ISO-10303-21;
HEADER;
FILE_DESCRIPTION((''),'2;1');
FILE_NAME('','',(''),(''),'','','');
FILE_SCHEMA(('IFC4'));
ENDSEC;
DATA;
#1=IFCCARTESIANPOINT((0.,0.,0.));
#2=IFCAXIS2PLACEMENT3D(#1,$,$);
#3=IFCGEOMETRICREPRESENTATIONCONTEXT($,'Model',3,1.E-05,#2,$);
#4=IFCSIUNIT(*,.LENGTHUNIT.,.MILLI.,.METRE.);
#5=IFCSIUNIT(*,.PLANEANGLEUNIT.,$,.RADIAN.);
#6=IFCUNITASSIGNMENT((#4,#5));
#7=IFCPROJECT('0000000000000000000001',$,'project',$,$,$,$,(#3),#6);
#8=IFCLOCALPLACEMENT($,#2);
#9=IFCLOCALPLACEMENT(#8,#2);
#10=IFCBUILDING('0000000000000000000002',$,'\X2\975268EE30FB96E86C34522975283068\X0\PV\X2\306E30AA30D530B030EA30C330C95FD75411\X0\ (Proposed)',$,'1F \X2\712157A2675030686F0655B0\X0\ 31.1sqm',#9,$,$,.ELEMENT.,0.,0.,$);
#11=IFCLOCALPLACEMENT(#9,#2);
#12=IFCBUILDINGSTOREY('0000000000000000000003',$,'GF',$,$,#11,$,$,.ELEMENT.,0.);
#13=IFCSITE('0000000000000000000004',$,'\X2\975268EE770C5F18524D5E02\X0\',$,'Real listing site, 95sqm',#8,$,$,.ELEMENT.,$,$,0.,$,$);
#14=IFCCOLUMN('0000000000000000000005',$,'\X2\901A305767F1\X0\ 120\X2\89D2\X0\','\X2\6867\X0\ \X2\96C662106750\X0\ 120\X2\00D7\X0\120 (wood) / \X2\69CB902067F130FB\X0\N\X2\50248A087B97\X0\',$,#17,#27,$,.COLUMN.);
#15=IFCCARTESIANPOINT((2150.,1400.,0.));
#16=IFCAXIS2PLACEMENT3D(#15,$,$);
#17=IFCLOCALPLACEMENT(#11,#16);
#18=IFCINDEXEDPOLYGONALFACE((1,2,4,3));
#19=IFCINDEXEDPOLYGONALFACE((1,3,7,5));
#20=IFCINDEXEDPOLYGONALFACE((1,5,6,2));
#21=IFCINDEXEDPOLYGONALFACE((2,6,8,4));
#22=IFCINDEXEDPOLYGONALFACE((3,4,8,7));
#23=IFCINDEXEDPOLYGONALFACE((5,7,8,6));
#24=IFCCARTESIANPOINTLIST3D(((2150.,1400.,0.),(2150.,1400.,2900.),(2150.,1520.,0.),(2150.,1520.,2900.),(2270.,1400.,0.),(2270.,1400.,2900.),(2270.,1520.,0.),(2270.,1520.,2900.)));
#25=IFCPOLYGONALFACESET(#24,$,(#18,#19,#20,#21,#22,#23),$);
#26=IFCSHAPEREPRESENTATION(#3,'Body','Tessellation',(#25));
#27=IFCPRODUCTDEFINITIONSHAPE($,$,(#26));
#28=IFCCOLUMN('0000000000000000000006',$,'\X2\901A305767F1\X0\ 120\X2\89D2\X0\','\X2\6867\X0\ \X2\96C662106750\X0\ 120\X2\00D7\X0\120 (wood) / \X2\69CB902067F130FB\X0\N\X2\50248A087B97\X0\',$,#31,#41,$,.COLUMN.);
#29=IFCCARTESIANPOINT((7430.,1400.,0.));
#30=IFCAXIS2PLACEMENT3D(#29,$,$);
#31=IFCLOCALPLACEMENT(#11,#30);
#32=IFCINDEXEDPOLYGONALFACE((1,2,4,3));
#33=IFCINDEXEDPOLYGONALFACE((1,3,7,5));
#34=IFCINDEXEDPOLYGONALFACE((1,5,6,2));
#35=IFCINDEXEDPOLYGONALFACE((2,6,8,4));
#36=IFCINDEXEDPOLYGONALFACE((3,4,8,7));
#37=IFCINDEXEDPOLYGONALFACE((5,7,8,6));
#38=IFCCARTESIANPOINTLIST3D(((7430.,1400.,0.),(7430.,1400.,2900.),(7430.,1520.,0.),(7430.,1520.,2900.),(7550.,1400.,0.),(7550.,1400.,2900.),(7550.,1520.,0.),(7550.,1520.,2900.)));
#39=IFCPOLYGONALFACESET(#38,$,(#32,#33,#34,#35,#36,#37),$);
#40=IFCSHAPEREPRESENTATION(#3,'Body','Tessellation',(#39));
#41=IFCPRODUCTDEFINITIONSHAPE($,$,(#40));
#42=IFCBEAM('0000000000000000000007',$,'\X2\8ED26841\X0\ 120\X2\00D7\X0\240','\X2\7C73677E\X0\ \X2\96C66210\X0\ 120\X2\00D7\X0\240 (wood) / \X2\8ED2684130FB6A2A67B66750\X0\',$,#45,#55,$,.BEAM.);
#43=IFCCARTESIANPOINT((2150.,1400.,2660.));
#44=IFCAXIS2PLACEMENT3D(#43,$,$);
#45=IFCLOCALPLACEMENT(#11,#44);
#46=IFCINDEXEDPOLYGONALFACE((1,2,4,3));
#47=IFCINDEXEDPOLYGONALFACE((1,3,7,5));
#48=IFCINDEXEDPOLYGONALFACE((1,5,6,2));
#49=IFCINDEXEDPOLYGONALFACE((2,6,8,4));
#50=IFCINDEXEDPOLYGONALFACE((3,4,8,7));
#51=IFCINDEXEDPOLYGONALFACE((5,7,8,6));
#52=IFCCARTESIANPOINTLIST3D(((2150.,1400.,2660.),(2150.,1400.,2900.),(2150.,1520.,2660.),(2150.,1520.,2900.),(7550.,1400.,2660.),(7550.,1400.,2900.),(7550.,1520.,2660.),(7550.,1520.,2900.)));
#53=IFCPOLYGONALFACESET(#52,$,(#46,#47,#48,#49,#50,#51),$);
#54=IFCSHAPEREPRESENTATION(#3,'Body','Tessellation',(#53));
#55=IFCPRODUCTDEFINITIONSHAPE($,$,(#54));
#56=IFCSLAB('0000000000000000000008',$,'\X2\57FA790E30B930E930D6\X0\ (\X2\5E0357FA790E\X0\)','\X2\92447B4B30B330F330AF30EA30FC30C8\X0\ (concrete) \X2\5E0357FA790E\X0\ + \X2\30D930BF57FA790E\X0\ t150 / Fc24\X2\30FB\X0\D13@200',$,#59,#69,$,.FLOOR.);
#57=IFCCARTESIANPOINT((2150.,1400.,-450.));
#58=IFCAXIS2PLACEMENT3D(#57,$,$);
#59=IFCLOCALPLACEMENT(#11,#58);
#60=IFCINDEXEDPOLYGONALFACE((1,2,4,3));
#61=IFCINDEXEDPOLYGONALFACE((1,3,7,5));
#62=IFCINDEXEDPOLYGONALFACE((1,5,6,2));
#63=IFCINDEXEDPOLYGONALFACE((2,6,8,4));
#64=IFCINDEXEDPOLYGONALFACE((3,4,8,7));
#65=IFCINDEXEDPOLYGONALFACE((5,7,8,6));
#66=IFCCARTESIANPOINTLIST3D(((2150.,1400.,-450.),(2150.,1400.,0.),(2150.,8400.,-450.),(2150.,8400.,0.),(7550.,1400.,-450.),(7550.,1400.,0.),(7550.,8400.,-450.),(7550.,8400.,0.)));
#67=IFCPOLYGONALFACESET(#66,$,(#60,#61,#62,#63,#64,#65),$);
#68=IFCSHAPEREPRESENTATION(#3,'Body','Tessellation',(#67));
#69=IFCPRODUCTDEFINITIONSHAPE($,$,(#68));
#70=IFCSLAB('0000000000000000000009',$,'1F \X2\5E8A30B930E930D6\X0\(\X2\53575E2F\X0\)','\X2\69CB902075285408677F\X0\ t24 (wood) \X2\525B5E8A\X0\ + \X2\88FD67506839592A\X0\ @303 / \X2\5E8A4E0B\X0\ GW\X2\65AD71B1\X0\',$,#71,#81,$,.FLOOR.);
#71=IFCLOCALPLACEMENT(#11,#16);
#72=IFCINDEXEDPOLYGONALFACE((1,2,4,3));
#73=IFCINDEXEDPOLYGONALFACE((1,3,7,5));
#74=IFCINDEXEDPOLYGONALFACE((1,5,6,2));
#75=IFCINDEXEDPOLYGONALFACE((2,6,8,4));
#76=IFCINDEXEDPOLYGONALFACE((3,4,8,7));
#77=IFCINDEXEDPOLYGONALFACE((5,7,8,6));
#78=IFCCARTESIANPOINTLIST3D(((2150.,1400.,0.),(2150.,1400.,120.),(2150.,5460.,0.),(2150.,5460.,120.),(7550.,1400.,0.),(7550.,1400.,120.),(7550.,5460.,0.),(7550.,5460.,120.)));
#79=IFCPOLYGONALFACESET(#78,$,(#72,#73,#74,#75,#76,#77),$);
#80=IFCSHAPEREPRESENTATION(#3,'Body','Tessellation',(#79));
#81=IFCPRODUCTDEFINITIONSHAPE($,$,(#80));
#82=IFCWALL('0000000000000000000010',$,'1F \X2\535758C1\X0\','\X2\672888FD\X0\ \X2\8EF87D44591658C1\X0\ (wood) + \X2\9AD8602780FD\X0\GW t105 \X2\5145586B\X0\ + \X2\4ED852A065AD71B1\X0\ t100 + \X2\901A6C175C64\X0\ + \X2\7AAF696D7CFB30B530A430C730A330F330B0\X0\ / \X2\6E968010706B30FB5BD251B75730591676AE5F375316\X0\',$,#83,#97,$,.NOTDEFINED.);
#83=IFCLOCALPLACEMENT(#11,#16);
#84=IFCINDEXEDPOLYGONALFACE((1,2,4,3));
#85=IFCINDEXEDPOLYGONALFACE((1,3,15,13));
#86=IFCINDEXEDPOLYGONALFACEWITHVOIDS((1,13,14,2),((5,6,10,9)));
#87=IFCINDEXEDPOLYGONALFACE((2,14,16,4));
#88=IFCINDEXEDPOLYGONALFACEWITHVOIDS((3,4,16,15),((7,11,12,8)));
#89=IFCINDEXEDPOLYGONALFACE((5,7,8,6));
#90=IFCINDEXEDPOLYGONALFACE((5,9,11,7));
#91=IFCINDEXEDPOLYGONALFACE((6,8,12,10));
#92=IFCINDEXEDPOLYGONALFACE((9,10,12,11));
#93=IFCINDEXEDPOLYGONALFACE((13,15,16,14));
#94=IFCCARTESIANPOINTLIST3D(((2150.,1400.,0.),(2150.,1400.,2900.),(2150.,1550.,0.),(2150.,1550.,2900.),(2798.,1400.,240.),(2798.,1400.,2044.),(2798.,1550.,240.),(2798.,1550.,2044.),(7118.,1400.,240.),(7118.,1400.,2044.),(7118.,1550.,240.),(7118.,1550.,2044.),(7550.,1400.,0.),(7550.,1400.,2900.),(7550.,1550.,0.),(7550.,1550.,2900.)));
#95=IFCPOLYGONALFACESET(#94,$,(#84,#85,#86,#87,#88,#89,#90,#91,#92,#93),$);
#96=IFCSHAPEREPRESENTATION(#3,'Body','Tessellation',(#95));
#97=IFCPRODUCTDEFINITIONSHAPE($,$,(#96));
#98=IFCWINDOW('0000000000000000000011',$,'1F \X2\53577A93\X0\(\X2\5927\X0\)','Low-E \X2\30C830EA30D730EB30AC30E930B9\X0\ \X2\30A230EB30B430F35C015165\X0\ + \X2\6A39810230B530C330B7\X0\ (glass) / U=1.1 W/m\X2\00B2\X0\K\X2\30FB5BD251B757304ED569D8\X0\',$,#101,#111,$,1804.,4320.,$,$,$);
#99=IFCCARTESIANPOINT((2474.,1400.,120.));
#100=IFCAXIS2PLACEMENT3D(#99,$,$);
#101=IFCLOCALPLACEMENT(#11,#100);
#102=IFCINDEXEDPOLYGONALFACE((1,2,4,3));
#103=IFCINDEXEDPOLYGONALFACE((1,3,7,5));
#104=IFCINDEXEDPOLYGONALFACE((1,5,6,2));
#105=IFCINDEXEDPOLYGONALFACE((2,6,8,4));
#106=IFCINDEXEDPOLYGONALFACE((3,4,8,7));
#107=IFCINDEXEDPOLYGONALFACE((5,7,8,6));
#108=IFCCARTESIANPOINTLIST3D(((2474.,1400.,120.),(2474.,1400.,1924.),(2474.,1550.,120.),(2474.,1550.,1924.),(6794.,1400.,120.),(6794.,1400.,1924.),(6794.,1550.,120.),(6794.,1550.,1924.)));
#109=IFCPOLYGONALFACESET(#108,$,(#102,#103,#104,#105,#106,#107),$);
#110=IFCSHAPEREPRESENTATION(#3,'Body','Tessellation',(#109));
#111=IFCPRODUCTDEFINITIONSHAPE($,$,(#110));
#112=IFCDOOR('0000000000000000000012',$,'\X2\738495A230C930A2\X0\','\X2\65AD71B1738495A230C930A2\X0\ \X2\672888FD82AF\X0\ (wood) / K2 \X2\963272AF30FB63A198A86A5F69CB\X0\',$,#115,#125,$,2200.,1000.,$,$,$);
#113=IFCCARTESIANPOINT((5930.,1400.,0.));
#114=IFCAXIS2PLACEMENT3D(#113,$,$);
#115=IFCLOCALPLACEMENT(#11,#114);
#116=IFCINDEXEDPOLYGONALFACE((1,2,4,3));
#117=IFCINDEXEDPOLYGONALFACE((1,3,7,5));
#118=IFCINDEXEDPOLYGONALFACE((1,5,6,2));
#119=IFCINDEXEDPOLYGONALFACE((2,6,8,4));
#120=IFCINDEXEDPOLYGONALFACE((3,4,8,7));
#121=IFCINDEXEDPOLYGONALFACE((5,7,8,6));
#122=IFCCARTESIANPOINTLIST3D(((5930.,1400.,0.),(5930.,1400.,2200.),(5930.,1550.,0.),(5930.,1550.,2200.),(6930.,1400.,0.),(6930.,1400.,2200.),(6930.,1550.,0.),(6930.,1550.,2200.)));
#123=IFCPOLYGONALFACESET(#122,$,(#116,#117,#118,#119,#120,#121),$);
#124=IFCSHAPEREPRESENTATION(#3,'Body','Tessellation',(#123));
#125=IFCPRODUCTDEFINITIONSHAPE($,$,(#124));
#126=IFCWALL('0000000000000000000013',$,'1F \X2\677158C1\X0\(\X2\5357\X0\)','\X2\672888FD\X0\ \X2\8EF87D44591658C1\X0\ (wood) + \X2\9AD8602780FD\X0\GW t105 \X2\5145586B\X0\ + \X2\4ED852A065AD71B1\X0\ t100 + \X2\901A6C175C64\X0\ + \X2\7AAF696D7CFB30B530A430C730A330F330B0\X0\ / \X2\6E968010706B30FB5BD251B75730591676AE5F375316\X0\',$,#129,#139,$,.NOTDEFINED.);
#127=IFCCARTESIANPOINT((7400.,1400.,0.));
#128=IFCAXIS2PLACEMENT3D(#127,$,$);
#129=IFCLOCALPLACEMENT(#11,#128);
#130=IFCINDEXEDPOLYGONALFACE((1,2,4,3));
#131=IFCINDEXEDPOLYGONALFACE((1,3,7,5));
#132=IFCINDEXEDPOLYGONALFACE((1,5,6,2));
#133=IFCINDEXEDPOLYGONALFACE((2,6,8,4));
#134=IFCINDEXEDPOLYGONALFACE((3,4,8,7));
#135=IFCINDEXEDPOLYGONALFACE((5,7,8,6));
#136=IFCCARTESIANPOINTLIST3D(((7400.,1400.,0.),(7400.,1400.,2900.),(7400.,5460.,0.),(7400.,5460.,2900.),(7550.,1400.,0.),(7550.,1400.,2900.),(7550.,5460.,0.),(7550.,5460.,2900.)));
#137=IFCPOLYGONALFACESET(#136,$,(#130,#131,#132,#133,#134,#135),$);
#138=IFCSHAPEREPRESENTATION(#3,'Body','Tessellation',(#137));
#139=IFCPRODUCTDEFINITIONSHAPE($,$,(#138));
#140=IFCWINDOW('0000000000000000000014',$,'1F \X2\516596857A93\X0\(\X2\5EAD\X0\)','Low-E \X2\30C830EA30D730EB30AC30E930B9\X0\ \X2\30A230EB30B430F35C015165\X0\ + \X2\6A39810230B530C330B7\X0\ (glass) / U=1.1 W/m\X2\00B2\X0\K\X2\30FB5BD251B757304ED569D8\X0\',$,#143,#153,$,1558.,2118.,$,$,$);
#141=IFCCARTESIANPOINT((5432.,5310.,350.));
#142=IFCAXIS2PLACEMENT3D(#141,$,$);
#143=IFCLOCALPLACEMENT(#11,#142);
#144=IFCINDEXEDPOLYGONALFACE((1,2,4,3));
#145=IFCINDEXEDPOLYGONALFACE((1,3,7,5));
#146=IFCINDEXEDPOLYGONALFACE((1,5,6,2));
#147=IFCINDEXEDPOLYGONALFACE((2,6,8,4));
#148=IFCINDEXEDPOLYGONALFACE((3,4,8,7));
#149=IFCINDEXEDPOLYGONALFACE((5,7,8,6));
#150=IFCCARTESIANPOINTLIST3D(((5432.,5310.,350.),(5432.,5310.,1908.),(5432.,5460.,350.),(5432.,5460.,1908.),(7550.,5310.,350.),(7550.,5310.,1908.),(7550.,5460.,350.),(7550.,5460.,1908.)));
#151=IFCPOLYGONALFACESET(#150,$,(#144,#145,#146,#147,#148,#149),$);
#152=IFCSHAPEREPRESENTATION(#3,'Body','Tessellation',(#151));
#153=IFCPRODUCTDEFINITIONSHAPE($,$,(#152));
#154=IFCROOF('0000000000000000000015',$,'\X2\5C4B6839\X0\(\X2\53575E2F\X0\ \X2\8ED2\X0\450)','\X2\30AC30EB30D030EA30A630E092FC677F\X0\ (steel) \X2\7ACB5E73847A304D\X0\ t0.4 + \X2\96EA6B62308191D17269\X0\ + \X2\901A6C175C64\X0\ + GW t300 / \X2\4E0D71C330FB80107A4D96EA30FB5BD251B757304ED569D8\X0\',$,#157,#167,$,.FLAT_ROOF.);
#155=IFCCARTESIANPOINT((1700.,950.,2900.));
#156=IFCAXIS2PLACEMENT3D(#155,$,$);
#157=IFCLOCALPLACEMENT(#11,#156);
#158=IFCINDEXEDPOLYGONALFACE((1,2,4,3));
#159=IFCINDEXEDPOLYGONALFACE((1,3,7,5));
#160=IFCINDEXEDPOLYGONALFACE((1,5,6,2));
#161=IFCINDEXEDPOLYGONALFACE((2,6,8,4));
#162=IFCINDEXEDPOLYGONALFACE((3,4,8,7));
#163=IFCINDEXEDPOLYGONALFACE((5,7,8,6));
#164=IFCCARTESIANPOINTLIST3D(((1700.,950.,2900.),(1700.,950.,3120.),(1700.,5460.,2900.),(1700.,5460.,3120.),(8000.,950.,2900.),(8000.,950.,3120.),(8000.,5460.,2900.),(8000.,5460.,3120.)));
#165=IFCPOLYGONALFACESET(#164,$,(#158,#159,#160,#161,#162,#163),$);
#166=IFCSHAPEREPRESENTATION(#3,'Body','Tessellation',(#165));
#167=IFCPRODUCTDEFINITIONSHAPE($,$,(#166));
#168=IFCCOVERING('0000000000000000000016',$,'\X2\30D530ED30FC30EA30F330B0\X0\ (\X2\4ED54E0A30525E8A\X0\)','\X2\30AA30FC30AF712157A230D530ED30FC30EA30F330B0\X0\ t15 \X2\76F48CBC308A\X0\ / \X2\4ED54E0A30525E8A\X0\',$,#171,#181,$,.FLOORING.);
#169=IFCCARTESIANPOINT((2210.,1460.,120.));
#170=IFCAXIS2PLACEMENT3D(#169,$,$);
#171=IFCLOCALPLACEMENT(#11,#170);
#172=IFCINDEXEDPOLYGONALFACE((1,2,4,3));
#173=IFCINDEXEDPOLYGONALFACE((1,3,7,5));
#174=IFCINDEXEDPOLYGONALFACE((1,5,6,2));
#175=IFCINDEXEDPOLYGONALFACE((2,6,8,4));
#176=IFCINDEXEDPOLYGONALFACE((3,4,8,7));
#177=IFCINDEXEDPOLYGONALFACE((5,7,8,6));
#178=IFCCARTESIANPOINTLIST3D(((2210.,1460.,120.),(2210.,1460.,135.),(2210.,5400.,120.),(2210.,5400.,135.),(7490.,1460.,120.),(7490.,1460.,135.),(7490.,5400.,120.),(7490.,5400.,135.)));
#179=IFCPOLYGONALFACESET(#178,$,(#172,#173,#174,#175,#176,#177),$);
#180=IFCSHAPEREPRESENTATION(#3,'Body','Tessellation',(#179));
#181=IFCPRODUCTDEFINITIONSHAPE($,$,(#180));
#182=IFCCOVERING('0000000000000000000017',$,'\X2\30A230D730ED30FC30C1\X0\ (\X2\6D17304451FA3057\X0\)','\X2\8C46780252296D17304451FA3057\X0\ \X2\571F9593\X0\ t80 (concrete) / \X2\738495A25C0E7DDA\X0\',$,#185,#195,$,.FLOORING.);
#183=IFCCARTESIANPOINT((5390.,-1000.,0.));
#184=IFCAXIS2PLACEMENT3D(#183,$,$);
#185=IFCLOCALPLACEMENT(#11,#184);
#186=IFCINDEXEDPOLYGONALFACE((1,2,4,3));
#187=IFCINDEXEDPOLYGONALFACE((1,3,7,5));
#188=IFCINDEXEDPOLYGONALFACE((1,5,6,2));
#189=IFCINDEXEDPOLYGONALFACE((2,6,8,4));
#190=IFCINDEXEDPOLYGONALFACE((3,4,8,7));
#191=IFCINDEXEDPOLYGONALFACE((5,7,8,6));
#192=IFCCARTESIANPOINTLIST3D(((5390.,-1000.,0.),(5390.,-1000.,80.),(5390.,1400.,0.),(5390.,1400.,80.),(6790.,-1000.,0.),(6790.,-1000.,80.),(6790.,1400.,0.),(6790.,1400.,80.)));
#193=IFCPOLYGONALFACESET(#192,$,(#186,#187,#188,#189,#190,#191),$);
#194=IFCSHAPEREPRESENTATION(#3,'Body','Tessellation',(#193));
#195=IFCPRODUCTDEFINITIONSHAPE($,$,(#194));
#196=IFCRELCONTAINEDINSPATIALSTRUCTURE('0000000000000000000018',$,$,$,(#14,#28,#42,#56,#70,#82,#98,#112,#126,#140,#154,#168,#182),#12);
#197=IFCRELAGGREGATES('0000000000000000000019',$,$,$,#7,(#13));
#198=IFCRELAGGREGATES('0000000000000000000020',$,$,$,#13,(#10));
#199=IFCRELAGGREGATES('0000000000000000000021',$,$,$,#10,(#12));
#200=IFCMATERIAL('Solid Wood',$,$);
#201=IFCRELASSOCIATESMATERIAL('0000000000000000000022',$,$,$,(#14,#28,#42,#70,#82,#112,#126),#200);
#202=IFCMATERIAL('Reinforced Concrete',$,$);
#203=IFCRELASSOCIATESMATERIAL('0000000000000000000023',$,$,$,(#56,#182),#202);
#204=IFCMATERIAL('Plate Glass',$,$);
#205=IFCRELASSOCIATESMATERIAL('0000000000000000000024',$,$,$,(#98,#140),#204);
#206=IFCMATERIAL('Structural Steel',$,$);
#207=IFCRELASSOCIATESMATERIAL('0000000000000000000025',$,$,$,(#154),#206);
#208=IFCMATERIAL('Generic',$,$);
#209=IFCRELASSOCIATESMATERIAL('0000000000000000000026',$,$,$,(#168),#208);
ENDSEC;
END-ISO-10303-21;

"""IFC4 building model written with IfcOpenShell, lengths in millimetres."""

from ifc_helpers import new_model, si_unit, frame, frame_2d, origin, place, context, project, spatial, rectangle, extrude, material, element, fill, save


model = new_model("IFC4")

# Units and contexts
model_context = context("Model", 3, precision=1e-05, world=origin())
ifc_project = project(units=[si_unit("LENGTHUNIT", "METRE", prefix="MILLI"), si_unit("PLANEANGLEUNIT", "RADIAN")], contexts=[model_context])

# Site, building, storey
site_placement = place(None, origin())
site = spatial("IfcSite", under=ifc_project, at=site_placement, Name="青森県弘前市", ObjectType="Real listing site, 95sqm", CompositionType="ELEMENT", RefElevation=0.0)
building_placement = place(site_placement, origin())
building = spatial("IfcBuilding", under=site, at=building_placement, Name="青森・雨水利用とPVのオフグリッド志向 (Proposed)", ObjectType="1F 無垢材と漆喰 31.1sqm", CompositionType="ELEMENT", ElevationOfRefHeight=0.0, ElevationOfTerrain=0.0)
storey_placement = place(building_placement, origin())
storey = spatial("IfcBuildingStorey", under=building, at=storey_placement, Name="GF", CompositionType="ELEMENT", Elevation=0.0)

# Columns
ifc_material_1 = material(Name="Solid Wood")
column_1_placement = place(storey_placement, frame((2150.0, 1400.0, 0.0)))
element("IfcColumn", 1, at=column_1_placement, inside=storey, material=ifc_material_1, Name="通し柱 120角", Description="桧 集成材 120×120 (wood) / 構造柱・N値計算", PredefinedType="COLUMN", context=model_context, shape_type="SweptSolid", body=[
    extrude(rectangle(XDim=120.0, YDim=120.0, at=frame_2d((60.0, 60.0))), frame((2150.0, 1400.0, 0.0)), (0.0, 0.0, 1.0), 2900.0),
])
column_2_placement = place(storey_placement, frame((7430.0, 1400.0, 0.0)))
element("IfcColumn", 2, at=column_2_placement, inside=storey, material=ifc_material_1, Name="通し柱 120角", Description="桧 集成材 120×120 (wood) / 構造柱・N値計算", PredefinedType="COLUMN", context=model_context, shape_type="SweptSolid", body=[
    extrude(rectangle(XDim=120.0, YDim=120.0, at=frame_2d((60.0, 60.0))), frame((7430.0, 1400.0, 0.0)), (0.0, 0.0, 1.0), 2900.0),
])

# Beam
beam_1_placement = place(storey_placement, frame((2150.0, 1400.0, 2660.0)))
element("IfcBeam", 3, at=beam_1_placement, inside=storey, material=ifc_material_1, Name="軒桁 120×240", Description="米松 集成 120×240 (wood) / 軒桁・横架材", PredefinedType="BEAM", context=model_context, shape_type="SweptSolid", body=[
    extrude(rectangle(XDim=5400.0, YDim=120.0, at=frame_2d((2700.0, 60.0))), frame((2150.0, 1400.0, 2660.0)), (0.0, 0.0, 1.0), 240.0),
])

# Slabs
ifc_material_2 = material(Name="Reinforced Concrete")
slab_1_placement = place(storey_placement, frame((2150.0, 1400.0, -450.0)))
element("IfcSlab", 4, at=slab_1_placement, inside=storey, material=ifc_material_2, Name="基礎スラブ (布基礎)", Description="鉄筋コンクリート (concrete) 布基礎 + ベタ基礎 t150 / Fc24・D13@200", PredefinedType="FLOOR", context=model_context, shape_type="SweptSolid", body=[
    extrude(rectangle(XDim=5400.0, YDim=7000.0, at=frame_2d((2700.0, 3500.0))), frame((2150.0, 1400.0, -450.0)), (0.0, 0.0, 1.0), 450.0),
])
slab_2_placement = place(storey_placement, frame((2150.0, 1400.0, 0.0)))
element("IfcSlab", 5, at=slab_2_placement, inside=storey, material=ifc_material_1, Name="1F 床スラブ(南帯)", Description="構造用合板 t24 (wood) 剛床 + 製材根太 @303 / 床下 GW断熱", PredefinedType="FLOOR", context=model_context, shape_type="SweptSolid", body=[
    extrude(rectangle(XDim=5400.0, YDim=4060.0, at=frame_2d((2700.0, 2030.0))), frame((2150.0, 1400.0, 0.0)), (0.0, 0.0, 1.0), 120.0),
])

# Wall, openings, window, door
wall_1_placement = place(storey_placement, frame((2150.0, 1400.0, 0.0)))
wall_1 = element("IfcWall", 6, at=wall_1_placement, inside=storey, material=ifc_material_1, Name="1F 南壁", Description="木製 軸組外壁 (wood) + 高性能GW t105 充填 + 付加断熱 t100 + 通気層 + 窯業系サイディング / 準耐火・寒冷地外皮強化", PredefinedType="NOTDEFINED", context=model_context, shape_type="SweptSolid", body=[
    extrude(rectangle(XDim=5400.0, YDim=150.0, at=frame_2d((2700.0, 75.0))), frame((2150.0, 1400.0, 0.0)), (0.0, 0.0, 1.0), 2900.0),
])
opening_1_placement = place(storey_placement, frame((2474.0, 1400.0, 120.0)))
opening_1 = element("IfcOpeningElement", 7, at=opening_1_placement, cuts=wall_1, PredefinedType="NOTDEFINED", context=model_context, shape_type="SweptSolid", body=[
    extrude(rectangle(XDim=4320.0, YDim=150.0, at=frame_2d((2160.0, 75.0))), frame((2474.0, 1400.0, 120.0)), (0.0, 0.0, 1.0), 1804.0),
])
opening_2_placement = place(storey_placement, frame((5930.0, 1400.0, 0.0)))
opening_2 = element("IfcOpeningElement", 8, at=opening_2_placement, cuts=wall_1, PredefinedType="NOTDEFINED", context=model_context, shape_type="SweptSolid", body=[
    extrude(rectangle(XDim=1000.0, YDim=150.0, at=frame_2d((500.0, 75.0))), frame((5930.0, 1400.0, 0.0)), (0.0, 0.0, 1.0), 2200.0),
])
ifc_material_3 = material(Name="Plate Glass")
window_1_placement = place(storey_placement, frame((2474.0, 1400.0, 120.0)))
window_1 = element("IfcWindow", 9, at=window_1_placement, inside=storey, material=ifc_material_3, Name="1F 南窓(大)", Description="Low-E トリプルガラス アルゴン封入 + 樹脂サッシ (glass) / U=1.1 W/m²K・寒冷地仕様", OverallHeight=1804.0, OverallWidth=4320.0, context=model_context, shape_type="SweptSolid", body=[
    extrude(rectangle(XDim=4320.0, YDim=150.0, at=frame_2d((2160.0, 75.0))), frame((2474.0, 1400.0, 120.0)), (0.0, 0.0, 1.0), 1804.0),
])
fill(opening_1, window_1)
door_1_placement = place(storey_placement, frame((5930.0, 1400.0, 0.0)))
door_1 = element("IfcDoor", 10, at=door_1_placement, inside=storey, material=ifc_material_1, Name="玄関ドア", Description="断熱玄関ドア 木製芯 (wood) / K2 防犯・採風機構", OverallHeight=2200.0, OverallWidth=1000.0, context=model_context, shape_type="SweptSolid", body=[
    extrude(rectangle(XDim=1000.0, YDim=150.0, at=frame_2d((500.0, 75.0))), frame((5930.0, 1400.0, 0.0)), (0.0, 0.0, 1.0), 2200.0),
])
fill(opening_2, door_1)

# Wall, opening, window
wall_2_placement = place(storey_placement, frame((7400.0, 1400.0, 0.0)))
wall_2 = element("IfcWall", 11, at=wall_2_placement, inside=storey, material=ifc_material_1, Name="1F 東壁(南)", Description="木製 軸組外壁 (wood) + 高性能GW t105 充填 + 付加断熱 t100 + 通気層 + 窯業系サイディング / 準耐火・寒冷地外皮強化", PredefinedType="NOTDEFINED", context=model_context, shape_type="SweptSolid", body=[
    extrude(rectangle(XDim=150.0, YDim=4060.0, at=frame_2d((75.0, 2030.0))), frame((7400.0, 1400.0, 0.0)), (0.0, 0.0, 1.0), 2900.0),
])
opening_3_placement = place(storey_placement, frame((5432.0, 5310.0, 350.0)))
opening_3 = element("IfcOpeningElement", 12, at=opening_3_placement, cuts=wall_2, PredefinedType="NOTDEFINED", context=model_context, shape_type="SweptSolid", body=[
    extrude(rectangle(XDim=2118.0, YDim=150.0, at=frame_2d((1059.0, 75.0))), frame((5432.0, 5310.0, 350.0)), (0.0, 0.0, 1.0), 1558.0),
])
window_2_placement = place(storey_placement, frame((5432.0, 5310.0, 350.0)))
window_2 = element("IfcWindow", 13, at=window_2_placement, inside=storey, material=ifc_material_3, Name="1F 入隅窓(庭)", Description="Low-E トリプルガラス アルゴン封入 + 樹脂サッシ (glass) / U=1.1 W/m²K・寒冷地仕様", OverallHeight=1558.0, OverallWidth=2118.0, context=model_context, shape_type="SweptSolid", body=[
    extrude(rectangle(XDim=2118.0, YDim=150.0, at=frame_2d((1059.0, 75.0))), frame((5432.0, 5310.0, 350.0)), (0.0, 0.0, 1.0), 1558.0),
])
fill(opening_3, window_2)

# Roof
ifc_material_4 = material(Name="Structural Steel")
roof_placement = place(storey_placement, frame((1700.0, 950.0, 2900.0)))
element("IfcRoof", 14, at=roof_placement, inside=storey, material=ifc_material_4, Name="屋根(南帯 軒450)", Description="ガルバリウム鋼板 (steel) 立平葺き t0.4 + 雪止め金物 + 通気層 + GW t300 / 不燃・耐積雪・寒冷地仕様", PredefinedType="FLAT_ROOF", context=model_context, shape_type="SweptSolid", body=[
    extrude(rectangle(XDim=6300.0, YDim=4510.0, at=frame_2d((3150.0, 2255.0))), frame((1700.0, 950.0, 2900.0)), (0.0, 0.0, 1.0), 220.0),
])

# Coverings
ifc_material_5 = material(Name="Generic")
covering_1_placement = place(storey_placement, frame((2210.0, 1460.0, 120.0)))
element("IfcCovering", 15, at=covering_1_placement, inside=storey, material=ifc_material_5, Name="フローリング (仕上げ床)", Description="オーク無垢フローリング t15 直貼り / 仕上げ床", PredefinedType="FLOORING", context=model_context, shape_type="SweptSolid", body=[
    extrude(rectangle(XDim=5280.0, YDim=3940.0, at=frame_2d((2640.0, 1970.0))), frame((2210.0, 1460.0, 120.0)), (0.0, 0.0, 1.0), 15.0),
])
covering_2_placement = place(storey_placement, frame((5390.0, -1000.0, 0.0)))
element("IfcCovering", 16, at=covering_2_placement, inside=storey, material=ifc_material_2, Name="アプローチ (洗い出し)", Description="豆砂利洗い出し 土間 t80 (concrete) / 玄関導線", PredefinedType="FLOORING", context=model_context, shape_type="SweptSolid", body=[
    extrude(rectangle(XDim=1400.0, YDim=2400.0, at=frame_2d((700.0, 1200.0))), frame((5390.0, -1000.0, 0.0)), (0.0, 0.0, 1.0), 80.0),
])

save(model, "model.ifc")
